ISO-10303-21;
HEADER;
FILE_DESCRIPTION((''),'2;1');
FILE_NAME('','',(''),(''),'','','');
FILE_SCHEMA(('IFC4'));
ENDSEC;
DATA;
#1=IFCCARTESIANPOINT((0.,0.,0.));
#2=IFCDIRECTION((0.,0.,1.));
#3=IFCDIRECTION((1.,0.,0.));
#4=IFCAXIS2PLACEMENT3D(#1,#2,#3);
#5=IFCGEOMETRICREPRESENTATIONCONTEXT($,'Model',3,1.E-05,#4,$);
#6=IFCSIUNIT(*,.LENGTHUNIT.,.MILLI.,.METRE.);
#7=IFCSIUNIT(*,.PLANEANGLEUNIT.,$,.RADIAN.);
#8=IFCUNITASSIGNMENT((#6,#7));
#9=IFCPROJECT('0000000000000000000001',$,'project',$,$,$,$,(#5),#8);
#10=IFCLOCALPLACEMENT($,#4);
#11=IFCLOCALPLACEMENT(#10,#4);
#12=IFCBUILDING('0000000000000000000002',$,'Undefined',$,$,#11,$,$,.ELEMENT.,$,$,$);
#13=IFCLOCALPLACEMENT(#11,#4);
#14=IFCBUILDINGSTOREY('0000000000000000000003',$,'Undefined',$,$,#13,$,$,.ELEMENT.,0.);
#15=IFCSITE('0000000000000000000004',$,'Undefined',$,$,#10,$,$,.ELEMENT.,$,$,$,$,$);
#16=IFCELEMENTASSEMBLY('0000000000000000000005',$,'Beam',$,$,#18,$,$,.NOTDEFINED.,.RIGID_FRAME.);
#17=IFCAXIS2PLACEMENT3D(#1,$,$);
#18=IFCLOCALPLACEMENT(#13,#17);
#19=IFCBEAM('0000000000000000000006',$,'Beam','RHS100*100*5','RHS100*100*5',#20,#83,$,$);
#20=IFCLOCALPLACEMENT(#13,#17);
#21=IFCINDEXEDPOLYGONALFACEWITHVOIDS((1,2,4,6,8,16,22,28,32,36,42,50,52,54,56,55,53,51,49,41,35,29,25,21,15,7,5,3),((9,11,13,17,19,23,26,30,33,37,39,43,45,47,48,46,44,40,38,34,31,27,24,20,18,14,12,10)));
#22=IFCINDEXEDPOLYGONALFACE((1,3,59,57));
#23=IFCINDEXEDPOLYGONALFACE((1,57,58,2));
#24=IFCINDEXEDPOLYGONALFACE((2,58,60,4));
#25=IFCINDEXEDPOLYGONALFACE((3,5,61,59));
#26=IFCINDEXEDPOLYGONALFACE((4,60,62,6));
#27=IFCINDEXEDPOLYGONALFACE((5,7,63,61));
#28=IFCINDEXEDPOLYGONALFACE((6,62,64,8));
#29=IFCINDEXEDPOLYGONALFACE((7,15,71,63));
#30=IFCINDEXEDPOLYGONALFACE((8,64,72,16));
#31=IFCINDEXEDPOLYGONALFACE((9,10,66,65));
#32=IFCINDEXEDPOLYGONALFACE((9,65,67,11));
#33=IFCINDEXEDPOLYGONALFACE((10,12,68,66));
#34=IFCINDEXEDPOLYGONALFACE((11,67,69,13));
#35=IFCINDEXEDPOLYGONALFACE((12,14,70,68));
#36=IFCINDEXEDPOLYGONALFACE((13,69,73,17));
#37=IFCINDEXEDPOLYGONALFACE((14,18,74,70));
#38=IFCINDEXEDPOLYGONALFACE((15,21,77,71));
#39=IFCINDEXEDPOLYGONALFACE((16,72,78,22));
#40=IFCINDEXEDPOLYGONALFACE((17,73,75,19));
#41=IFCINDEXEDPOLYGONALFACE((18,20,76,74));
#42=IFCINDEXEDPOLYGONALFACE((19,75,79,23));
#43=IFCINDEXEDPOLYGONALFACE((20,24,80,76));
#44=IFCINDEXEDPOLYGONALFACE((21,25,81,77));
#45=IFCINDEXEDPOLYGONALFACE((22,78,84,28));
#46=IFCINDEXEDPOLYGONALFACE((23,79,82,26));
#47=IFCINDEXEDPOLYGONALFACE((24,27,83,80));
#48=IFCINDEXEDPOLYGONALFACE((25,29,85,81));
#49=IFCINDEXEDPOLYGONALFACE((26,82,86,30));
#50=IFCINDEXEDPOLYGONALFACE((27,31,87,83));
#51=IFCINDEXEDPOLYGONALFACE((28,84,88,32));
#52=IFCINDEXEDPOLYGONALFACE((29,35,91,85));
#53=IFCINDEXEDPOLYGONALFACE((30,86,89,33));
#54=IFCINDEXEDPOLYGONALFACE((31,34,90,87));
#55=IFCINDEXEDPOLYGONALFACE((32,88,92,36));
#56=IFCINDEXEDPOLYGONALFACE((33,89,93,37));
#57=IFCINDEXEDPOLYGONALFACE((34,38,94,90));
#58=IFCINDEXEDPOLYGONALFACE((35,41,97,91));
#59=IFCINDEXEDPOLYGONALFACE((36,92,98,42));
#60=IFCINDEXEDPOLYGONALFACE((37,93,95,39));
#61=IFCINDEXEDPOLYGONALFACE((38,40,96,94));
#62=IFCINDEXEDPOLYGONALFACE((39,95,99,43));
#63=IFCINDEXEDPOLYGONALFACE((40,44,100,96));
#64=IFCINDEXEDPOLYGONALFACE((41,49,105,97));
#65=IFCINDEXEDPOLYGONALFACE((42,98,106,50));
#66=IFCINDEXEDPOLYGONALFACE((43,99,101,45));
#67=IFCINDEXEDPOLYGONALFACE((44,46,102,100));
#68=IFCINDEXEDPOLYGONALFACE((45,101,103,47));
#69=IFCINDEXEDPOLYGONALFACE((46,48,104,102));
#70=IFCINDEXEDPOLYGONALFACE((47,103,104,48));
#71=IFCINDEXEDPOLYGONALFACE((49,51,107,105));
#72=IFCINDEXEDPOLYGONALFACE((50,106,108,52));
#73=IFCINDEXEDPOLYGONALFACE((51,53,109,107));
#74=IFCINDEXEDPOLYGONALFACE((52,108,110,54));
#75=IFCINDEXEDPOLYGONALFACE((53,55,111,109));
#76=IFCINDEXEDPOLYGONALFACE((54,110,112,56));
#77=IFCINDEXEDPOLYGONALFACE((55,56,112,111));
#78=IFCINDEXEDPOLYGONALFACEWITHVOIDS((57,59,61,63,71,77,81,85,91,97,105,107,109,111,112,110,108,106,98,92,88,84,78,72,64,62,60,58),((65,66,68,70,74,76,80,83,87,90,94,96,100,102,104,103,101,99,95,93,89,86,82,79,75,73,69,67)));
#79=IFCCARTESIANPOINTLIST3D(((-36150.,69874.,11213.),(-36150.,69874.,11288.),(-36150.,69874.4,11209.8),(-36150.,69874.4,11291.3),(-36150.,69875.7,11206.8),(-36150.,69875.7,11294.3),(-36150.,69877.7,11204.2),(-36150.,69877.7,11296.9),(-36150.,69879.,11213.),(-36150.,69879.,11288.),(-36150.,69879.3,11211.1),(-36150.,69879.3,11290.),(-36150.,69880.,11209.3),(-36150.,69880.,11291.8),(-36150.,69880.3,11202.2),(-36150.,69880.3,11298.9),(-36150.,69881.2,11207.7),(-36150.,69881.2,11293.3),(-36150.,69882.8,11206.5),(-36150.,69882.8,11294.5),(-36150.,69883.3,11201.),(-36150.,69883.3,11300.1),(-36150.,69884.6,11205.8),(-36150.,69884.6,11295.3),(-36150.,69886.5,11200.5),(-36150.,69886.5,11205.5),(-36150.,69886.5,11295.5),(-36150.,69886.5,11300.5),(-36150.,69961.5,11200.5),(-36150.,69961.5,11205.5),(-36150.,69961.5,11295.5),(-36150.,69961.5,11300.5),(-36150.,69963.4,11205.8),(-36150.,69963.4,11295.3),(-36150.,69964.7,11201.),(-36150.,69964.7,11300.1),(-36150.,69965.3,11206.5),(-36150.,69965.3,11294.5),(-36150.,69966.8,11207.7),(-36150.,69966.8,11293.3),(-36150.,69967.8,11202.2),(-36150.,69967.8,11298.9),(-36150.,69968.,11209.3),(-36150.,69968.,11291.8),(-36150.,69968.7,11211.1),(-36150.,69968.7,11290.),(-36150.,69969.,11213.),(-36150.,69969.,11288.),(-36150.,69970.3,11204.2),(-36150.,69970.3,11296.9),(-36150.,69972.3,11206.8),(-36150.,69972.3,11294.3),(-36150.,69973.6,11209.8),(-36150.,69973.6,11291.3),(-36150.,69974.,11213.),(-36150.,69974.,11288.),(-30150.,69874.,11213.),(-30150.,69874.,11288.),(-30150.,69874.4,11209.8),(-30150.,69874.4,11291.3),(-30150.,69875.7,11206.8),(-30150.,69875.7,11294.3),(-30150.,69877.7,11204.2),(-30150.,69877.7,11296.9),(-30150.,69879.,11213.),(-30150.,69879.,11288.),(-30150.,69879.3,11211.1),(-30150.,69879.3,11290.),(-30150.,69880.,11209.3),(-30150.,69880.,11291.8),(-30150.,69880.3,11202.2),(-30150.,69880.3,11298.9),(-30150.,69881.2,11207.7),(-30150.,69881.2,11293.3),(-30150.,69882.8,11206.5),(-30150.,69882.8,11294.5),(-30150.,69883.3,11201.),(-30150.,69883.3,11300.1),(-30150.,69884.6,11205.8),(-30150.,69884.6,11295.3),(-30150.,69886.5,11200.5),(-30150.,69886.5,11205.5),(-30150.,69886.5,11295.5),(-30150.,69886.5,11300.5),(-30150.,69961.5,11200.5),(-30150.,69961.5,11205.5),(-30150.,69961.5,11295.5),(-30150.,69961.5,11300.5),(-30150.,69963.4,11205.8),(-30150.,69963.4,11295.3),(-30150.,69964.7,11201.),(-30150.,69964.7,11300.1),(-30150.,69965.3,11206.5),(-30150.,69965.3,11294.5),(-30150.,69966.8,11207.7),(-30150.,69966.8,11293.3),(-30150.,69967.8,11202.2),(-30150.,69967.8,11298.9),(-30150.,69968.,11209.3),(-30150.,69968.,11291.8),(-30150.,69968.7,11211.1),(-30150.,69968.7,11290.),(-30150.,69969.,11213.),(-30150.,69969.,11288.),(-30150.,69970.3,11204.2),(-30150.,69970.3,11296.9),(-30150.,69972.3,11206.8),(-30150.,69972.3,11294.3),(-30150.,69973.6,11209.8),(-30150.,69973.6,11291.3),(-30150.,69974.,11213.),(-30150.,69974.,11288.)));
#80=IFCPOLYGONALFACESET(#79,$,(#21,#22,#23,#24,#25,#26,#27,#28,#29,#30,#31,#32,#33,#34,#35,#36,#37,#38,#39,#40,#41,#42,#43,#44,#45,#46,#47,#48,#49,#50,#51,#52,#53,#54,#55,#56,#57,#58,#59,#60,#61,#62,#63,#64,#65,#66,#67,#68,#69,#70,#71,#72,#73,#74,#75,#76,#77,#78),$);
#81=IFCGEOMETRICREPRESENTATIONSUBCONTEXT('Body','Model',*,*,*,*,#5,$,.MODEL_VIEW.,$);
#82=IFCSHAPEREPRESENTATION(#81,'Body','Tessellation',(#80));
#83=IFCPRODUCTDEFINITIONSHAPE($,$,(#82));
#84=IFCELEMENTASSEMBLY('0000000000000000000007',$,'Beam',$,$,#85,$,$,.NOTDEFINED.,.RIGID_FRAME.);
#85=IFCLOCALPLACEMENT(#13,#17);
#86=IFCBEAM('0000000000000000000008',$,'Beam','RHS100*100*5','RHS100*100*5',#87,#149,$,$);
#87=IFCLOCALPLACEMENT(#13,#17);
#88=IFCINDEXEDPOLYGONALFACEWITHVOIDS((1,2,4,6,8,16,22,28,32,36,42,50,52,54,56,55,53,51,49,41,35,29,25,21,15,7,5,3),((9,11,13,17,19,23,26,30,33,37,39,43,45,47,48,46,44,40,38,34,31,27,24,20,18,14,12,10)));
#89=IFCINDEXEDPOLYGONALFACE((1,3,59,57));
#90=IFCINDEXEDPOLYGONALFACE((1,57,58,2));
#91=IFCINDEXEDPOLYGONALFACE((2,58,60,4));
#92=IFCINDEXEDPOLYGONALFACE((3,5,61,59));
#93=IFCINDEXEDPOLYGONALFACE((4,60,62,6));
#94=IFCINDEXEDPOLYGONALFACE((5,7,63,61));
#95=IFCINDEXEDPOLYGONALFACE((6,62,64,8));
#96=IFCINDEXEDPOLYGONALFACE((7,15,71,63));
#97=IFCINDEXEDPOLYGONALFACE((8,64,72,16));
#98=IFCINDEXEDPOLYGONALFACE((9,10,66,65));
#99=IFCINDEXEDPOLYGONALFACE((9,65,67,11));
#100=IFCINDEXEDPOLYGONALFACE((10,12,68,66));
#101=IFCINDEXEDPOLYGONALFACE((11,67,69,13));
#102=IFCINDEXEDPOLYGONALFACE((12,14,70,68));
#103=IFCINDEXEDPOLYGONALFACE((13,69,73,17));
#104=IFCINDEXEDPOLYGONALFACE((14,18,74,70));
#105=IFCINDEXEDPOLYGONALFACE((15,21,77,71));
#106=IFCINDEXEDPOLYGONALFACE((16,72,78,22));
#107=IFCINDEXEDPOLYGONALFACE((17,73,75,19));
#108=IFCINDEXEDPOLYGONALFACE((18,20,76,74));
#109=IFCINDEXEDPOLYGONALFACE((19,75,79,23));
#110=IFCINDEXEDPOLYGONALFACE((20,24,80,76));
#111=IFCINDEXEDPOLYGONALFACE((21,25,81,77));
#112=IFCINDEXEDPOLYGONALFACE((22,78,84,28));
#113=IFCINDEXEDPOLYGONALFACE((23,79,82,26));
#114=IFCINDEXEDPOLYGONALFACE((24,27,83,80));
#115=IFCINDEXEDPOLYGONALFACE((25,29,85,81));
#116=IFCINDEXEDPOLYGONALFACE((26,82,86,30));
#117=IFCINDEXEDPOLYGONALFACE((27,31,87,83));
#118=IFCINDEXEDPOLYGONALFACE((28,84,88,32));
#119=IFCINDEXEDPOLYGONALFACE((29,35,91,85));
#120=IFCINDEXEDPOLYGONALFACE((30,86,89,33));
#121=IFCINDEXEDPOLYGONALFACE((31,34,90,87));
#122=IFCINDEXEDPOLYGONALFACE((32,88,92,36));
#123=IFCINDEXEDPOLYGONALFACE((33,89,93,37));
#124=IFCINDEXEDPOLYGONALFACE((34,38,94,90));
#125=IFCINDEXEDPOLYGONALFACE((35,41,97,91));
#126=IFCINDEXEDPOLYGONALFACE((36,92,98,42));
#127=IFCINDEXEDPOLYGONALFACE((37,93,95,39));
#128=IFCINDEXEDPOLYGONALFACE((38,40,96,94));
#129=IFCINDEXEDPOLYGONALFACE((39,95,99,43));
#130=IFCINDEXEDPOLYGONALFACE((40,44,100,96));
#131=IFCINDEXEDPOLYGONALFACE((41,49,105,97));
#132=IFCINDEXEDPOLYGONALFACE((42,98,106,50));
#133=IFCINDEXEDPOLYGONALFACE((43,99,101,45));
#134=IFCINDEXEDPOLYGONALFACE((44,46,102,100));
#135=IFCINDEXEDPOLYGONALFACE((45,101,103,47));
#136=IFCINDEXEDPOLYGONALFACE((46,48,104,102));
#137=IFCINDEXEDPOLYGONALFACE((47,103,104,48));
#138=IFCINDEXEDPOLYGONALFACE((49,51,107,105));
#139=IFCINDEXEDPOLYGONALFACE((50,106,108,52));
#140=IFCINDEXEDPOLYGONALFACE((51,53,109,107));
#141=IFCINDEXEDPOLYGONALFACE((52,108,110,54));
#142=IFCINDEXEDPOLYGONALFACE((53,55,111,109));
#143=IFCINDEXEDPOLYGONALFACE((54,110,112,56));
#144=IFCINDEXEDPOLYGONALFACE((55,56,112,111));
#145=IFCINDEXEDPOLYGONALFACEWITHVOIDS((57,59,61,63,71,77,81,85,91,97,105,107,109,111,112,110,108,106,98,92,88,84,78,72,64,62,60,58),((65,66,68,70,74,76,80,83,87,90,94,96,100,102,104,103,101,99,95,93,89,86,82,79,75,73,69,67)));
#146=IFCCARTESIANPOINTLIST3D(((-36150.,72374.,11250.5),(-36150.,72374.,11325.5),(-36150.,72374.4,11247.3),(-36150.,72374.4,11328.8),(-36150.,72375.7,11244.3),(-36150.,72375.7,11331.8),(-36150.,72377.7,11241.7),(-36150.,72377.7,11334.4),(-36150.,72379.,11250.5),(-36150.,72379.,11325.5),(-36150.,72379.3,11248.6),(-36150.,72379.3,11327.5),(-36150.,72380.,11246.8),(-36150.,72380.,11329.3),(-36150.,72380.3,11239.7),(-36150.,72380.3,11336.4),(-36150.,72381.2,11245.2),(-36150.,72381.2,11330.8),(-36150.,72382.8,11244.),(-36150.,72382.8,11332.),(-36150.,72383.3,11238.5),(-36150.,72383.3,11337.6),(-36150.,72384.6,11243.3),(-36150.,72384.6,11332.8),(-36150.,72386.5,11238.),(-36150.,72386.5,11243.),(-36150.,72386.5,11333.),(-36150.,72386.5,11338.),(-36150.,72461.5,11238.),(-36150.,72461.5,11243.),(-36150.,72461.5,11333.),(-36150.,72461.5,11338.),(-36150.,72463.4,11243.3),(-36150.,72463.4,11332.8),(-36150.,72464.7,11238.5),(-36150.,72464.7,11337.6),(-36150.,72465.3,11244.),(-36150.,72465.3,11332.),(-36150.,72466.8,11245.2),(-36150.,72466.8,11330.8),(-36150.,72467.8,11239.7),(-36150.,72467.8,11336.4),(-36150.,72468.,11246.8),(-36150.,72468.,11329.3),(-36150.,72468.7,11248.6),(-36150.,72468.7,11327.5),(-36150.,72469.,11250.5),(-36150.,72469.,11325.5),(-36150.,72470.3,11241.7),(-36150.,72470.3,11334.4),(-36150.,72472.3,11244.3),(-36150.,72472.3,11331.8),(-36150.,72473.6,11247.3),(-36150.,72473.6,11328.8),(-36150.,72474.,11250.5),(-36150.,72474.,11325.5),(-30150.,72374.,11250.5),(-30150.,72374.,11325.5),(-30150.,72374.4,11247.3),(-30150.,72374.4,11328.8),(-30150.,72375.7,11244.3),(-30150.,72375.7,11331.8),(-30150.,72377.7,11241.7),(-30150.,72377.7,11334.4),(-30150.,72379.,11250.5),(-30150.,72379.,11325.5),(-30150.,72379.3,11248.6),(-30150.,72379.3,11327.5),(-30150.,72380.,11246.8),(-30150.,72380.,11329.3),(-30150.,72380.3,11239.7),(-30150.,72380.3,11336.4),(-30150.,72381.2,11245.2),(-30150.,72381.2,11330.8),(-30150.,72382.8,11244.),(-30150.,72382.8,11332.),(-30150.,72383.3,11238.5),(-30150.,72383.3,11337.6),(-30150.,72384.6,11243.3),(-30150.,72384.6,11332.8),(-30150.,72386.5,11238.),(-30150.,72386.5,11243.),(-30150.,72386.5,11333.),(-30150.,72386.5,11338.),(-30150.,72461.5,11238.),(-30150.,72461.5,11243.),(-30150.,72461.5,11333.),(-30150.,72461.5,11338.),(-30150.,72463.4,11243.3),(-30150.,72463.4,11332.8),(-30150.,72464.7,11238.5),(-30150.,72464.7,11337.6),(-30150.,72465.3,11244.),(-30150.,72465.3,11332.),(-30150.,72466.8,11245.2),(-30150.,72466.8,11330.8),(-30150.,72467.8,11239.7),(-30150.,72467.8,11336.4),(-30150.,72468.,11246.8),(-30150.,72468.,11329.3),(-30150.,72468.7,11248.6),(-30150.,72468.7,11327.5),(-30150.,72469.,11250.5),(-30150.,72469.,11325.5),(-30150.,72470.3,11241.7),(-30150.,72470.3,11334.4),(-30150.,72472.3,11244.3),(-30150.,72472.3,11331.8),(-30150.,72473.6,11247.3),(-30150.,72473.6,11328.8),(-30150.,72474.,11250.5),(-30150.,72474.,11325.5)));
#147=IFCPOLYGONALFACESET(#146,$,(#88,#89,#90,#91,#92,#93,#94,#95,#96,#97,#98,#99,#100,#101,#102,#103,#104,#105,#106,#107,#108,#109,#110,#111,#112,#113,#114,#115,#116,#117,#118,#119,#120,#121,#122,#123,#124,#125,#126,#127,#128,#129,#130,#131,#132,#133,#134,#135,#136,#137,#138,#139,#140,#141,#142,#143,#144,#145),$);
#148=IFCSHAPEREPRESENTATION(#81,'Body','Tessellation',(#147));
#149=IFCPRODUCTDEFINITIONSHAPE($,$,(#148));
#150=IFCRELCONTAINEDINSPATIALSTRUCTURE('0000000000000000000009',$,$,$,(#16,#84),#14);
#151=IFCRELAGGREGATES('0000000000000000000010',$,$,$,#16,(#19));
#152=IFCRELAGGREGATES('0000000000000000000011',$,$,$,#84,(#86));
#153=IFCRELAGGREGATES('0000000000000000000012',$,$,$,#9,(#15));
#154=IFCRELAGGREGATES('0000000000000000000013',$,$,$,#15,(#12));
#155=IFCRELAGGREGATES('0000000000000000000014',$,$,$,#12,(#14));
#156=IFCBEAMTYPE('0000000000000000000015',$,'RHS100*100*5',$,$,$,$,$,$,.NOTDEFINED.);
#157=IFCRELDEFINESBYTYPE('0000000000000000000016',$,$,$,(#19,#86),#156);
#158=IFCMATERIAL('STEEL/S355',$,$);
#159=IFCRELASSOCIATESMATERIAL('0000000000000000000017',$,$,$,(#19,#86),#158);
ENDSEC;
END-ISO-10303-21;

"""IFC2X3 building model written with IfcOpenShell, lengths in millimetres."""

from ifc_helpers import new_model, si_unit, frame, origin_with_axes, origin_2d_with_axis, place, context, subcontext, project, spatial, hollow_rectangle, extrude, material, type_object, element, aggregate, save


model = new_model("IFC2X3")

# Units and contexts
model_context = context("Model", 3, precision=1e-05, world=origin_with_axes())
body_context = subcontext(model_context, "Body", "Model", "MODEL_VIEW")
ifc_project = project(units=[si_unit("LENGTHUNIT", "METRE", prefix="MILLI"), si_unit("PLANEANGLEUNIT", "RADIAN")], contexts=[model_context])

# Site, building, storey
site_placement = place(None, origin_with_axes())
site = spatial("IfcSite", under=ifc_project, at=site_placement, Name="Undefined", CompositionType="ELEMENT")
building_placement = place(site_placement, origin_with_axes())
building = spatial("IfcBuilding", under=site, at=building_placement, Name="Undefined", CompositionType="ELEMENT")
storey_placement = place(building_placement, origin_with_axes())
storey = spatial("IfcBuildingStorey", under=building, at=storey_placement, Name="Undefined", CompositionType="ELEMENT", Elevation=0.0)

# Shared definitions
ifc_material = material(Name="STEEL/S355")

# Element assemblies, beams
beam_type_1 = type_object("IfcBeamType", Name="RHS100*100*5", PredefinedType="NOTDEFINED")
assembly_1_placement = place(storey_placement, origin_with_axes())
assembly_1 = element("IfcElementAssembly", 1, at=assembly_1_placement, inside=storey, Name="Beam", AssemblyPlace="NOTDEFINED", PredefinedType="RIGID_FRAME")
beam_1_placement = place(assembly_1_placement, frame((-30150.0, 69924.0, 11250.5), z_axis=(0.0, 0.0, 1.0), x_axis=(-1.0, 0.0, 0.0)))
beam_1 = element("IfcBeam", 2, at=beam_1_placement, type_object=beam_type_1, material=ifc_material, Name="Beam", Description="RHS100*100*5", ObjectType="RHS100*100*5", context=body_context, shape_type="SweptSolid", body=[
    extrude(hollow_rectangle(XDim=100.0, YDim=100.0, WallThickness=5.0, InnerFilletRadius=7.5, OuterFilletRadius=12.5, at=origin_2d_with_axis()), frame((6000.0, 0.0, 0.0), z_axis=(-1.0, 0.0, 0.0), x_axis=(0.0, -1.0, 0.0)), (0.0, 0.0, 1.0), 6000.0),
])
aggregate(assembly_1, [beam_1])
assembly_2_placement = place(storey_placement, origin_with_axes())
assembly_2 = element("IfcElementAssembly", 3, at=assembly_2_placement, inside=storey, Name="Beam", AssemblyPlace="NOTDEFINED", PredefinedType="RIGID_FRAME")
beam_2_placement = place(assembly_2_placement, frame((-30150.0, 72424.0, 11288.0), z_axis=(0.0, 0.0, 1.0), x_axis=(-1.0, 0.0, 0.0)))
beam_2 = element("IfcBeam", 4, at=beam_2_placement, type_object=beam_type_1, material=ifc_material, Name="Beam", Description="RHS100*100*5", ObjectType="RHS100*100*5", context=body_context, shape_type="SweptSolid", body=[
    extrude(hollow_rectangle(XDim=100.0, YDim=100.0, WallThickness=5.0, InnerFilletRadius=7.5, OuterFilletRadius=12.5, at=origin_2d_with_axis()), frame((6000.0, 0.0, 0.0), z_axis=(-1.0, 0.0, 0.0), x_axis=(0.0, -1.0, 0.0)), (0.0, 0.0, 1.0), 6000.0),
])
aggregate(assembly_2, [beam_2])

save(model, "model.ifc")
